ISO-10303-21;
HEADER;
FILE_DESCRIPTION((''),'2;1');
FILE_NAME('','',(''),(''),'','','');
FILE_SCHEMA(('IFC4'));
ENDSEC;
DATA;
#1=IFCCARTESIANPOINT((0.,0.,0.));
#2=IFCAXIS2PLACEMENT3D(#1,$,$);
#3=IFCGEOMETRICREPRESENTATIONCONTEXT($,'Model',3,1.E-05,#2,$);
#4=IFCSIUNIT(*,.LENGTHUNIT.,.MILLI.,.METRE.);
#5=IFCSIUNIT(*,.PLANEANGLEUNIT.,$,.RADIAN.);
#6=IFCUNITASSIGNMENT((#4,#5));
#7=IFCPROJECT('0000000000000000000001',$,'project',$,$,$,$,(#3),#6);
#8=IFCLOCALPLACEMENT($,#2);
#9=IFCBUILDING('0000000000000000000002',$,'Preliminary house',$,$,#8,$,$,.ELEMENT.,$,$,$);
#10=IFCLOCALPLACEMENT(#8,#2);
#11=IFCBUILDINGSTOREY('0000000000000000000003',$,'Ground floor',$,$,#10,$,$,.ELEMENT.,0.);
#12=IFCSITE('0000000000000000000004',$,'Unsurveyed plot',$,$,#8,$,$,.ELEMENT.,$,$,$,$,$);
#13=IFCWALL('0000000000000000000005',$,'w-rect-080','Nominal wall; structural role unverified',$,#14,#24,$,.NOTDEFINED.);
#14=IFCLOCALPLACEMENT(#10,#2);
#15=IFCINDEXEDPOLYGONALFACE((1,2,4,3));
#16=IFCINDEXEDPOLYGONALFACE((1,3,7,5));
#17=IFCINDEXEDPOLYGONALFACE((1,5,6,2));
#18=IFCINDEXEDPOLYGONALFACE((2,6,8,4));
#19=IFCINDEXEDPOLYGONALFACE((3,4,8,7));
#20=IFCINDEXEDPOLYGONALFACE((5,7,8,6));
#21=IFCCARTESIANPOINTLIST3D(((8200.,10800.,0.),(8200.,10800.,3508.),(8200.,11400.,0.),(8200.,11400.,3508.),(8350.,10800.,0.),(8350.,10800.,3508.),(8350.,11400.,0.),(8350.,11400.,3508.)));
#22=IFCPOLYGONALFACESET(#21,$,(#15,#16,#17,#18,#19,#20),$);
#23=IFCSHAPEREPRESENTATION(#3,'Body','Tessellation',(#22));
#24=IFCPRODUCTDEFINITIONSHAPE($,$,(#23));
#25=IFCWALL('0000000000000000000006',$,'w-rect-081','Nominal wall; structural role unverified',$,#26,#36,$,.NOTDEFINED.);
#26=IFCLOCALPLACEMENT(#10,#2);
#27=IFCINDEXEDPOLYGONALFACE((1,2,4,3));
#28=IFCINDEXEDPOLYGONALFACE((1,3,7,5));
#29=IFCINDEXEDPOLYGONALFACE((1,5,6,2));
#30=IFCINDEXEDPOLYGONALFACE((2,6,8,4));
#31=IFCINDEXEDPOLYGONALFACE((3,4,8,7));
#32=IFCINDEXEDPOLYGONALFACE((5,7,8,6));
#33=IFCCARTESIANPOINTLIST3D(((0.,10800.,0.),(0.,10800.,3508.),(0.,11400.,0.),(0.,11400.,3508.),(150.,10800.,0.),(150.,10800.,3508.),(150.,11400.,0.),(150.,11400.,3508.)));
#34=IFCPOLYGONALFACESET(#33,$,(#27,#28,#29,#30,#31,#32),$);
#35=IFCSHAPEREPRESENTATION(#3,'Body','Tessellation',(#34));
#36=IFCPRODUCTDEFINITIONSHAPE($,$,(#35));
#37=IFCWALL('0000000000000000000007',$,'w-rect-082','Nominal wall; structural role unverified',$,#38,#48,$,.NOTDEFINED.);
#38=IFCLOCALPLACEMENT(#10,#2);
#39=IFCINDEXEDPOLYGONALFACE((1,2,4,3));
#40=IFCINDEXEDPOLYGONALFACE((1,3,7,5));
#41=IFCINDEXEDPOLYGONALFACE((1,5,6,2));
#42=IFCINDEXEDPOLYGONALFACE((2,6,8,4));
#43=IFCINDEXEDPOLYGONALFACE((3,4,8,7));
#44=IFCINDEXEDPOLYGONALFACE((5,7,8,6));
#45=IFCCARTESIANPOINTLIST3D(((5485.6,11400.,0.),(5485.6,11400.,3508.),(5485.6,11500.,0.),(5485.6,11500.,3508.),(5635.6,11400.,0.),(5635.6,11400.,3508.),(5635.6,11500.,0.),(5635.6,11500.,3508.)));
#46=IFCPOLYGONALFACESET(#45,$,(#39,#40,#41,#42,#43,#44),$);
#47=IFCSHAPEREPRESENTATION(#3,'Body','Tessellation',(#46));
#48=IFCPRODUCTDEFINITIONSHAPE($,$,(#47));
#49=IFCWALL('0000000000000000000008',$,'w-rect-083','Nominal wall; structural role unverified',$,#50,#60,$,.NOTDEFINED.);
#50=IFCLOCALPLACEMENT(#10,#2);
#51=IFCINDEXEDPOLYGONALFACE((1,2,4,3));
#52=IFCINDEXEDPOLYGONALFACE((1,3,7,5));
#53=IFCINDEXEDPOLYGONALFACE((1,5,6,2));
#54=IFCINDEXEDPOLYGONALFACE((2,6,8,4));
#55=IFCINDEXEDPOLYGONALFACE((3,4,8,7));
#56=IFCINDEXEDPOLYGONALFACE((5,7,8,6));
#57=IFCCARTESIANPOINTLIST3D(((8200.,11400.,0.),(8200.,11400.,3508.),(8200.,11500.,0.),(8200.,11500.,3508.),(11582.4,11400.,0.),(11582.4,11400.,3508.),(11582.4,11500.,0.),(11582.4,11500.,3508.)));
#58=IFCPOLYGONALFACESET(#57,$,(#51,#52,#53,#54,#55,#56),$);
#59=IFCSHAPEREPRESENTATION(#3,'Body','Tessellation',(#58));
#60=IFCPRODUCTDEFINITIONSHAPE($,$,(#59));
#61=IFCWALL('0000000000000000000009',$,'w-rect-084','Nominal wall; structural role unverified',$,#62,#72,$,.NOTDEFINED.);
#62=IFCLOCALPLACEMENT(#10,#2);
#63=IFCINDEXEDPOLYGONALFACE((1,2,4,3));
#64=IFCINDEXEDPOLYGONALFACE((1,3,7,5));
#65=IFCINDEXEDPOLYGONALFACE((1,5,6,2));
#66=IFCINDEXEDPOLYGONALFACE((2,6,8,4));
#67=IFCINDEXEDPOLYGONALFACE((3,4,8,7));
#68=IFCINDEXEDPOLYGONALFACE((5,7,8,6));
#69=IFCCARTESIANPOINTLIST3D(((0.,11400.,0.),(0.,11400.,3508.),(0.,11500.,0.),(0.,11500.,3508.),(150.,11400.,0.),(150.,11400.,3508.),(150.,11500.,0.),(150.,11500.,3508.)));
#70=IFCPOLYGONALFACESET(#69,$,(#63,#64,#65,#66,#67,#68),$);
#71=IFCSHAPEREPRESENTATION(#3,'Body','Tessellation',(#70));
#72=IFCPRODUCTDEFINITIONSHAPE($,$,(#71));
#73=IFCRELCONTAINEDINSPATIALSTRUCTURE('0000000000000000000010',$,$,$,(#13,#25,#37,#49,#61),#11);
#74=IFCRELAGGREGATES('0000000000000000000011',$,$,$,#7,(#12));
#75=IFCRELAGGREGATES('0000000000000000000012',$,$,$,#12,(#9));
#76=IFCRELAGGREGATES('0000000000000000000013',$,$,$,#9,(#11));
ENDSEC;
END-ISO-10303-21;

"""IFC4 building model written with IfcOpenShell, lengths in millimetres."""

from ifc_helpers import new_model, si_unit, origin, place, context, project, spatial, polyline, outline, extrude, element, save


model = new_model("IFC4")

# Units and contexts
model_context = context("Model", 3, precision=1e-05, world=origin())
ifc_project = project(units=[si_unit("LENGTHUNIT", "METRE", prefix="MILLI"), si_unit("PLANEANGLEUNIT", "RADIAN")], contexts=[model_context])

# Site, building, storey
placement_1 = place(None, origin())
site = spatial("IfcSite", under=ifc_project, at=placement_1, Name="Unsurveyed plot", CompositionType="ELEMENT")
building = spatial("IfcBuilding", under=site, at=placement_1, Name="Preliminary house", CompositionType="ELEMENT")
placement_2 = place(placement_1, origin())
storey = spatial("IfcBuildingStorey", under=building, at=placement_2, Name="Ground floor", CompositionType="ELEMENT", Elevation=0.0)

# Walls
element("IfcWall", 1, at=placement_2, inside=storey, Name="w-rect-080", Description="Nominal wall; structural role unverified", PredefinedType="NOTDEFINED", context=model_context, shape_type="SweptSolid", body=[
    extrude(outline(polyline([(8200.0, 10800.0), (8350.0, 10800.0), (8350.0, 11400.0), (8200.0, 11400.0), (8200.0, 10800.0)])), origin(), (0.0, 0.0, 1.0), 3508.0),
])
element("IfcWall", 2, at=placement_2, inside=storey, Name="w-rect-081", Description="Nominal wall; structural role unverified", PredefinedType="NOTDEFINED", context=model_context, shape_type="SweptSolid", body=[
    extrude(outline(polyline([(0.0, 10800.0), (150.0, 10800.0), (150.0, 11400.0), (0.0, 11400.0), (0.0, 10800.0)])), origin(), (0.0, 0.0, 1.0), 3508.0),
])
element("IfcWall", 3, at=placement_2, inside=storey, Name="w-rect-082", Description="Nominal wall; structural role unverified", PredefinedType="NOTDEFINED", context=model_context, shape_type="SweptSolid", body=[
    extrude(outline(polyline([(5485.6, 11400.0), (5635.6, 11400.0), (5635.6, 11500.0), (5485.6, 11500.0), (5485.6, 11400.0)])), origin(), (0.0, 0.0, 1.0), 3508.0),
])
element("IfcWall", 4, at=placement_2, inside=storey, Name="w-rect-083", Description="Nominal wall; structural role unverified", PredefinedType="NOTDEFINED", context=model_context, shape_type="SweptSolid", body=[
    extrude(outline(polyline([(8200.0, 11400.0), (11582.4, 11400.0), (11582.4, 11500.0), (8200.0, 11500.0), (8200.0, 11400.0)])), origin(), (0.0, 0.0, 1.0), 3508.0),
])
element("IfcWall", 5, at=placement_2, inside=storey, Name="w-rect-084", Description="Nominal wall; structural role unverified", PredefinedType="NOTDEFINED", context=model_context, shape_type="SweptSolid", body=[
    extrude(outline(polyline([(0.0, 11400.0), (150.0, 11400.0), (150.0, 11500.0), (0.0, 11500.0), (0.0, 11400.0)])), origin(), (0.0, 0.0, 1.0), 3508.0),
])

save(model, "model.ifc")
